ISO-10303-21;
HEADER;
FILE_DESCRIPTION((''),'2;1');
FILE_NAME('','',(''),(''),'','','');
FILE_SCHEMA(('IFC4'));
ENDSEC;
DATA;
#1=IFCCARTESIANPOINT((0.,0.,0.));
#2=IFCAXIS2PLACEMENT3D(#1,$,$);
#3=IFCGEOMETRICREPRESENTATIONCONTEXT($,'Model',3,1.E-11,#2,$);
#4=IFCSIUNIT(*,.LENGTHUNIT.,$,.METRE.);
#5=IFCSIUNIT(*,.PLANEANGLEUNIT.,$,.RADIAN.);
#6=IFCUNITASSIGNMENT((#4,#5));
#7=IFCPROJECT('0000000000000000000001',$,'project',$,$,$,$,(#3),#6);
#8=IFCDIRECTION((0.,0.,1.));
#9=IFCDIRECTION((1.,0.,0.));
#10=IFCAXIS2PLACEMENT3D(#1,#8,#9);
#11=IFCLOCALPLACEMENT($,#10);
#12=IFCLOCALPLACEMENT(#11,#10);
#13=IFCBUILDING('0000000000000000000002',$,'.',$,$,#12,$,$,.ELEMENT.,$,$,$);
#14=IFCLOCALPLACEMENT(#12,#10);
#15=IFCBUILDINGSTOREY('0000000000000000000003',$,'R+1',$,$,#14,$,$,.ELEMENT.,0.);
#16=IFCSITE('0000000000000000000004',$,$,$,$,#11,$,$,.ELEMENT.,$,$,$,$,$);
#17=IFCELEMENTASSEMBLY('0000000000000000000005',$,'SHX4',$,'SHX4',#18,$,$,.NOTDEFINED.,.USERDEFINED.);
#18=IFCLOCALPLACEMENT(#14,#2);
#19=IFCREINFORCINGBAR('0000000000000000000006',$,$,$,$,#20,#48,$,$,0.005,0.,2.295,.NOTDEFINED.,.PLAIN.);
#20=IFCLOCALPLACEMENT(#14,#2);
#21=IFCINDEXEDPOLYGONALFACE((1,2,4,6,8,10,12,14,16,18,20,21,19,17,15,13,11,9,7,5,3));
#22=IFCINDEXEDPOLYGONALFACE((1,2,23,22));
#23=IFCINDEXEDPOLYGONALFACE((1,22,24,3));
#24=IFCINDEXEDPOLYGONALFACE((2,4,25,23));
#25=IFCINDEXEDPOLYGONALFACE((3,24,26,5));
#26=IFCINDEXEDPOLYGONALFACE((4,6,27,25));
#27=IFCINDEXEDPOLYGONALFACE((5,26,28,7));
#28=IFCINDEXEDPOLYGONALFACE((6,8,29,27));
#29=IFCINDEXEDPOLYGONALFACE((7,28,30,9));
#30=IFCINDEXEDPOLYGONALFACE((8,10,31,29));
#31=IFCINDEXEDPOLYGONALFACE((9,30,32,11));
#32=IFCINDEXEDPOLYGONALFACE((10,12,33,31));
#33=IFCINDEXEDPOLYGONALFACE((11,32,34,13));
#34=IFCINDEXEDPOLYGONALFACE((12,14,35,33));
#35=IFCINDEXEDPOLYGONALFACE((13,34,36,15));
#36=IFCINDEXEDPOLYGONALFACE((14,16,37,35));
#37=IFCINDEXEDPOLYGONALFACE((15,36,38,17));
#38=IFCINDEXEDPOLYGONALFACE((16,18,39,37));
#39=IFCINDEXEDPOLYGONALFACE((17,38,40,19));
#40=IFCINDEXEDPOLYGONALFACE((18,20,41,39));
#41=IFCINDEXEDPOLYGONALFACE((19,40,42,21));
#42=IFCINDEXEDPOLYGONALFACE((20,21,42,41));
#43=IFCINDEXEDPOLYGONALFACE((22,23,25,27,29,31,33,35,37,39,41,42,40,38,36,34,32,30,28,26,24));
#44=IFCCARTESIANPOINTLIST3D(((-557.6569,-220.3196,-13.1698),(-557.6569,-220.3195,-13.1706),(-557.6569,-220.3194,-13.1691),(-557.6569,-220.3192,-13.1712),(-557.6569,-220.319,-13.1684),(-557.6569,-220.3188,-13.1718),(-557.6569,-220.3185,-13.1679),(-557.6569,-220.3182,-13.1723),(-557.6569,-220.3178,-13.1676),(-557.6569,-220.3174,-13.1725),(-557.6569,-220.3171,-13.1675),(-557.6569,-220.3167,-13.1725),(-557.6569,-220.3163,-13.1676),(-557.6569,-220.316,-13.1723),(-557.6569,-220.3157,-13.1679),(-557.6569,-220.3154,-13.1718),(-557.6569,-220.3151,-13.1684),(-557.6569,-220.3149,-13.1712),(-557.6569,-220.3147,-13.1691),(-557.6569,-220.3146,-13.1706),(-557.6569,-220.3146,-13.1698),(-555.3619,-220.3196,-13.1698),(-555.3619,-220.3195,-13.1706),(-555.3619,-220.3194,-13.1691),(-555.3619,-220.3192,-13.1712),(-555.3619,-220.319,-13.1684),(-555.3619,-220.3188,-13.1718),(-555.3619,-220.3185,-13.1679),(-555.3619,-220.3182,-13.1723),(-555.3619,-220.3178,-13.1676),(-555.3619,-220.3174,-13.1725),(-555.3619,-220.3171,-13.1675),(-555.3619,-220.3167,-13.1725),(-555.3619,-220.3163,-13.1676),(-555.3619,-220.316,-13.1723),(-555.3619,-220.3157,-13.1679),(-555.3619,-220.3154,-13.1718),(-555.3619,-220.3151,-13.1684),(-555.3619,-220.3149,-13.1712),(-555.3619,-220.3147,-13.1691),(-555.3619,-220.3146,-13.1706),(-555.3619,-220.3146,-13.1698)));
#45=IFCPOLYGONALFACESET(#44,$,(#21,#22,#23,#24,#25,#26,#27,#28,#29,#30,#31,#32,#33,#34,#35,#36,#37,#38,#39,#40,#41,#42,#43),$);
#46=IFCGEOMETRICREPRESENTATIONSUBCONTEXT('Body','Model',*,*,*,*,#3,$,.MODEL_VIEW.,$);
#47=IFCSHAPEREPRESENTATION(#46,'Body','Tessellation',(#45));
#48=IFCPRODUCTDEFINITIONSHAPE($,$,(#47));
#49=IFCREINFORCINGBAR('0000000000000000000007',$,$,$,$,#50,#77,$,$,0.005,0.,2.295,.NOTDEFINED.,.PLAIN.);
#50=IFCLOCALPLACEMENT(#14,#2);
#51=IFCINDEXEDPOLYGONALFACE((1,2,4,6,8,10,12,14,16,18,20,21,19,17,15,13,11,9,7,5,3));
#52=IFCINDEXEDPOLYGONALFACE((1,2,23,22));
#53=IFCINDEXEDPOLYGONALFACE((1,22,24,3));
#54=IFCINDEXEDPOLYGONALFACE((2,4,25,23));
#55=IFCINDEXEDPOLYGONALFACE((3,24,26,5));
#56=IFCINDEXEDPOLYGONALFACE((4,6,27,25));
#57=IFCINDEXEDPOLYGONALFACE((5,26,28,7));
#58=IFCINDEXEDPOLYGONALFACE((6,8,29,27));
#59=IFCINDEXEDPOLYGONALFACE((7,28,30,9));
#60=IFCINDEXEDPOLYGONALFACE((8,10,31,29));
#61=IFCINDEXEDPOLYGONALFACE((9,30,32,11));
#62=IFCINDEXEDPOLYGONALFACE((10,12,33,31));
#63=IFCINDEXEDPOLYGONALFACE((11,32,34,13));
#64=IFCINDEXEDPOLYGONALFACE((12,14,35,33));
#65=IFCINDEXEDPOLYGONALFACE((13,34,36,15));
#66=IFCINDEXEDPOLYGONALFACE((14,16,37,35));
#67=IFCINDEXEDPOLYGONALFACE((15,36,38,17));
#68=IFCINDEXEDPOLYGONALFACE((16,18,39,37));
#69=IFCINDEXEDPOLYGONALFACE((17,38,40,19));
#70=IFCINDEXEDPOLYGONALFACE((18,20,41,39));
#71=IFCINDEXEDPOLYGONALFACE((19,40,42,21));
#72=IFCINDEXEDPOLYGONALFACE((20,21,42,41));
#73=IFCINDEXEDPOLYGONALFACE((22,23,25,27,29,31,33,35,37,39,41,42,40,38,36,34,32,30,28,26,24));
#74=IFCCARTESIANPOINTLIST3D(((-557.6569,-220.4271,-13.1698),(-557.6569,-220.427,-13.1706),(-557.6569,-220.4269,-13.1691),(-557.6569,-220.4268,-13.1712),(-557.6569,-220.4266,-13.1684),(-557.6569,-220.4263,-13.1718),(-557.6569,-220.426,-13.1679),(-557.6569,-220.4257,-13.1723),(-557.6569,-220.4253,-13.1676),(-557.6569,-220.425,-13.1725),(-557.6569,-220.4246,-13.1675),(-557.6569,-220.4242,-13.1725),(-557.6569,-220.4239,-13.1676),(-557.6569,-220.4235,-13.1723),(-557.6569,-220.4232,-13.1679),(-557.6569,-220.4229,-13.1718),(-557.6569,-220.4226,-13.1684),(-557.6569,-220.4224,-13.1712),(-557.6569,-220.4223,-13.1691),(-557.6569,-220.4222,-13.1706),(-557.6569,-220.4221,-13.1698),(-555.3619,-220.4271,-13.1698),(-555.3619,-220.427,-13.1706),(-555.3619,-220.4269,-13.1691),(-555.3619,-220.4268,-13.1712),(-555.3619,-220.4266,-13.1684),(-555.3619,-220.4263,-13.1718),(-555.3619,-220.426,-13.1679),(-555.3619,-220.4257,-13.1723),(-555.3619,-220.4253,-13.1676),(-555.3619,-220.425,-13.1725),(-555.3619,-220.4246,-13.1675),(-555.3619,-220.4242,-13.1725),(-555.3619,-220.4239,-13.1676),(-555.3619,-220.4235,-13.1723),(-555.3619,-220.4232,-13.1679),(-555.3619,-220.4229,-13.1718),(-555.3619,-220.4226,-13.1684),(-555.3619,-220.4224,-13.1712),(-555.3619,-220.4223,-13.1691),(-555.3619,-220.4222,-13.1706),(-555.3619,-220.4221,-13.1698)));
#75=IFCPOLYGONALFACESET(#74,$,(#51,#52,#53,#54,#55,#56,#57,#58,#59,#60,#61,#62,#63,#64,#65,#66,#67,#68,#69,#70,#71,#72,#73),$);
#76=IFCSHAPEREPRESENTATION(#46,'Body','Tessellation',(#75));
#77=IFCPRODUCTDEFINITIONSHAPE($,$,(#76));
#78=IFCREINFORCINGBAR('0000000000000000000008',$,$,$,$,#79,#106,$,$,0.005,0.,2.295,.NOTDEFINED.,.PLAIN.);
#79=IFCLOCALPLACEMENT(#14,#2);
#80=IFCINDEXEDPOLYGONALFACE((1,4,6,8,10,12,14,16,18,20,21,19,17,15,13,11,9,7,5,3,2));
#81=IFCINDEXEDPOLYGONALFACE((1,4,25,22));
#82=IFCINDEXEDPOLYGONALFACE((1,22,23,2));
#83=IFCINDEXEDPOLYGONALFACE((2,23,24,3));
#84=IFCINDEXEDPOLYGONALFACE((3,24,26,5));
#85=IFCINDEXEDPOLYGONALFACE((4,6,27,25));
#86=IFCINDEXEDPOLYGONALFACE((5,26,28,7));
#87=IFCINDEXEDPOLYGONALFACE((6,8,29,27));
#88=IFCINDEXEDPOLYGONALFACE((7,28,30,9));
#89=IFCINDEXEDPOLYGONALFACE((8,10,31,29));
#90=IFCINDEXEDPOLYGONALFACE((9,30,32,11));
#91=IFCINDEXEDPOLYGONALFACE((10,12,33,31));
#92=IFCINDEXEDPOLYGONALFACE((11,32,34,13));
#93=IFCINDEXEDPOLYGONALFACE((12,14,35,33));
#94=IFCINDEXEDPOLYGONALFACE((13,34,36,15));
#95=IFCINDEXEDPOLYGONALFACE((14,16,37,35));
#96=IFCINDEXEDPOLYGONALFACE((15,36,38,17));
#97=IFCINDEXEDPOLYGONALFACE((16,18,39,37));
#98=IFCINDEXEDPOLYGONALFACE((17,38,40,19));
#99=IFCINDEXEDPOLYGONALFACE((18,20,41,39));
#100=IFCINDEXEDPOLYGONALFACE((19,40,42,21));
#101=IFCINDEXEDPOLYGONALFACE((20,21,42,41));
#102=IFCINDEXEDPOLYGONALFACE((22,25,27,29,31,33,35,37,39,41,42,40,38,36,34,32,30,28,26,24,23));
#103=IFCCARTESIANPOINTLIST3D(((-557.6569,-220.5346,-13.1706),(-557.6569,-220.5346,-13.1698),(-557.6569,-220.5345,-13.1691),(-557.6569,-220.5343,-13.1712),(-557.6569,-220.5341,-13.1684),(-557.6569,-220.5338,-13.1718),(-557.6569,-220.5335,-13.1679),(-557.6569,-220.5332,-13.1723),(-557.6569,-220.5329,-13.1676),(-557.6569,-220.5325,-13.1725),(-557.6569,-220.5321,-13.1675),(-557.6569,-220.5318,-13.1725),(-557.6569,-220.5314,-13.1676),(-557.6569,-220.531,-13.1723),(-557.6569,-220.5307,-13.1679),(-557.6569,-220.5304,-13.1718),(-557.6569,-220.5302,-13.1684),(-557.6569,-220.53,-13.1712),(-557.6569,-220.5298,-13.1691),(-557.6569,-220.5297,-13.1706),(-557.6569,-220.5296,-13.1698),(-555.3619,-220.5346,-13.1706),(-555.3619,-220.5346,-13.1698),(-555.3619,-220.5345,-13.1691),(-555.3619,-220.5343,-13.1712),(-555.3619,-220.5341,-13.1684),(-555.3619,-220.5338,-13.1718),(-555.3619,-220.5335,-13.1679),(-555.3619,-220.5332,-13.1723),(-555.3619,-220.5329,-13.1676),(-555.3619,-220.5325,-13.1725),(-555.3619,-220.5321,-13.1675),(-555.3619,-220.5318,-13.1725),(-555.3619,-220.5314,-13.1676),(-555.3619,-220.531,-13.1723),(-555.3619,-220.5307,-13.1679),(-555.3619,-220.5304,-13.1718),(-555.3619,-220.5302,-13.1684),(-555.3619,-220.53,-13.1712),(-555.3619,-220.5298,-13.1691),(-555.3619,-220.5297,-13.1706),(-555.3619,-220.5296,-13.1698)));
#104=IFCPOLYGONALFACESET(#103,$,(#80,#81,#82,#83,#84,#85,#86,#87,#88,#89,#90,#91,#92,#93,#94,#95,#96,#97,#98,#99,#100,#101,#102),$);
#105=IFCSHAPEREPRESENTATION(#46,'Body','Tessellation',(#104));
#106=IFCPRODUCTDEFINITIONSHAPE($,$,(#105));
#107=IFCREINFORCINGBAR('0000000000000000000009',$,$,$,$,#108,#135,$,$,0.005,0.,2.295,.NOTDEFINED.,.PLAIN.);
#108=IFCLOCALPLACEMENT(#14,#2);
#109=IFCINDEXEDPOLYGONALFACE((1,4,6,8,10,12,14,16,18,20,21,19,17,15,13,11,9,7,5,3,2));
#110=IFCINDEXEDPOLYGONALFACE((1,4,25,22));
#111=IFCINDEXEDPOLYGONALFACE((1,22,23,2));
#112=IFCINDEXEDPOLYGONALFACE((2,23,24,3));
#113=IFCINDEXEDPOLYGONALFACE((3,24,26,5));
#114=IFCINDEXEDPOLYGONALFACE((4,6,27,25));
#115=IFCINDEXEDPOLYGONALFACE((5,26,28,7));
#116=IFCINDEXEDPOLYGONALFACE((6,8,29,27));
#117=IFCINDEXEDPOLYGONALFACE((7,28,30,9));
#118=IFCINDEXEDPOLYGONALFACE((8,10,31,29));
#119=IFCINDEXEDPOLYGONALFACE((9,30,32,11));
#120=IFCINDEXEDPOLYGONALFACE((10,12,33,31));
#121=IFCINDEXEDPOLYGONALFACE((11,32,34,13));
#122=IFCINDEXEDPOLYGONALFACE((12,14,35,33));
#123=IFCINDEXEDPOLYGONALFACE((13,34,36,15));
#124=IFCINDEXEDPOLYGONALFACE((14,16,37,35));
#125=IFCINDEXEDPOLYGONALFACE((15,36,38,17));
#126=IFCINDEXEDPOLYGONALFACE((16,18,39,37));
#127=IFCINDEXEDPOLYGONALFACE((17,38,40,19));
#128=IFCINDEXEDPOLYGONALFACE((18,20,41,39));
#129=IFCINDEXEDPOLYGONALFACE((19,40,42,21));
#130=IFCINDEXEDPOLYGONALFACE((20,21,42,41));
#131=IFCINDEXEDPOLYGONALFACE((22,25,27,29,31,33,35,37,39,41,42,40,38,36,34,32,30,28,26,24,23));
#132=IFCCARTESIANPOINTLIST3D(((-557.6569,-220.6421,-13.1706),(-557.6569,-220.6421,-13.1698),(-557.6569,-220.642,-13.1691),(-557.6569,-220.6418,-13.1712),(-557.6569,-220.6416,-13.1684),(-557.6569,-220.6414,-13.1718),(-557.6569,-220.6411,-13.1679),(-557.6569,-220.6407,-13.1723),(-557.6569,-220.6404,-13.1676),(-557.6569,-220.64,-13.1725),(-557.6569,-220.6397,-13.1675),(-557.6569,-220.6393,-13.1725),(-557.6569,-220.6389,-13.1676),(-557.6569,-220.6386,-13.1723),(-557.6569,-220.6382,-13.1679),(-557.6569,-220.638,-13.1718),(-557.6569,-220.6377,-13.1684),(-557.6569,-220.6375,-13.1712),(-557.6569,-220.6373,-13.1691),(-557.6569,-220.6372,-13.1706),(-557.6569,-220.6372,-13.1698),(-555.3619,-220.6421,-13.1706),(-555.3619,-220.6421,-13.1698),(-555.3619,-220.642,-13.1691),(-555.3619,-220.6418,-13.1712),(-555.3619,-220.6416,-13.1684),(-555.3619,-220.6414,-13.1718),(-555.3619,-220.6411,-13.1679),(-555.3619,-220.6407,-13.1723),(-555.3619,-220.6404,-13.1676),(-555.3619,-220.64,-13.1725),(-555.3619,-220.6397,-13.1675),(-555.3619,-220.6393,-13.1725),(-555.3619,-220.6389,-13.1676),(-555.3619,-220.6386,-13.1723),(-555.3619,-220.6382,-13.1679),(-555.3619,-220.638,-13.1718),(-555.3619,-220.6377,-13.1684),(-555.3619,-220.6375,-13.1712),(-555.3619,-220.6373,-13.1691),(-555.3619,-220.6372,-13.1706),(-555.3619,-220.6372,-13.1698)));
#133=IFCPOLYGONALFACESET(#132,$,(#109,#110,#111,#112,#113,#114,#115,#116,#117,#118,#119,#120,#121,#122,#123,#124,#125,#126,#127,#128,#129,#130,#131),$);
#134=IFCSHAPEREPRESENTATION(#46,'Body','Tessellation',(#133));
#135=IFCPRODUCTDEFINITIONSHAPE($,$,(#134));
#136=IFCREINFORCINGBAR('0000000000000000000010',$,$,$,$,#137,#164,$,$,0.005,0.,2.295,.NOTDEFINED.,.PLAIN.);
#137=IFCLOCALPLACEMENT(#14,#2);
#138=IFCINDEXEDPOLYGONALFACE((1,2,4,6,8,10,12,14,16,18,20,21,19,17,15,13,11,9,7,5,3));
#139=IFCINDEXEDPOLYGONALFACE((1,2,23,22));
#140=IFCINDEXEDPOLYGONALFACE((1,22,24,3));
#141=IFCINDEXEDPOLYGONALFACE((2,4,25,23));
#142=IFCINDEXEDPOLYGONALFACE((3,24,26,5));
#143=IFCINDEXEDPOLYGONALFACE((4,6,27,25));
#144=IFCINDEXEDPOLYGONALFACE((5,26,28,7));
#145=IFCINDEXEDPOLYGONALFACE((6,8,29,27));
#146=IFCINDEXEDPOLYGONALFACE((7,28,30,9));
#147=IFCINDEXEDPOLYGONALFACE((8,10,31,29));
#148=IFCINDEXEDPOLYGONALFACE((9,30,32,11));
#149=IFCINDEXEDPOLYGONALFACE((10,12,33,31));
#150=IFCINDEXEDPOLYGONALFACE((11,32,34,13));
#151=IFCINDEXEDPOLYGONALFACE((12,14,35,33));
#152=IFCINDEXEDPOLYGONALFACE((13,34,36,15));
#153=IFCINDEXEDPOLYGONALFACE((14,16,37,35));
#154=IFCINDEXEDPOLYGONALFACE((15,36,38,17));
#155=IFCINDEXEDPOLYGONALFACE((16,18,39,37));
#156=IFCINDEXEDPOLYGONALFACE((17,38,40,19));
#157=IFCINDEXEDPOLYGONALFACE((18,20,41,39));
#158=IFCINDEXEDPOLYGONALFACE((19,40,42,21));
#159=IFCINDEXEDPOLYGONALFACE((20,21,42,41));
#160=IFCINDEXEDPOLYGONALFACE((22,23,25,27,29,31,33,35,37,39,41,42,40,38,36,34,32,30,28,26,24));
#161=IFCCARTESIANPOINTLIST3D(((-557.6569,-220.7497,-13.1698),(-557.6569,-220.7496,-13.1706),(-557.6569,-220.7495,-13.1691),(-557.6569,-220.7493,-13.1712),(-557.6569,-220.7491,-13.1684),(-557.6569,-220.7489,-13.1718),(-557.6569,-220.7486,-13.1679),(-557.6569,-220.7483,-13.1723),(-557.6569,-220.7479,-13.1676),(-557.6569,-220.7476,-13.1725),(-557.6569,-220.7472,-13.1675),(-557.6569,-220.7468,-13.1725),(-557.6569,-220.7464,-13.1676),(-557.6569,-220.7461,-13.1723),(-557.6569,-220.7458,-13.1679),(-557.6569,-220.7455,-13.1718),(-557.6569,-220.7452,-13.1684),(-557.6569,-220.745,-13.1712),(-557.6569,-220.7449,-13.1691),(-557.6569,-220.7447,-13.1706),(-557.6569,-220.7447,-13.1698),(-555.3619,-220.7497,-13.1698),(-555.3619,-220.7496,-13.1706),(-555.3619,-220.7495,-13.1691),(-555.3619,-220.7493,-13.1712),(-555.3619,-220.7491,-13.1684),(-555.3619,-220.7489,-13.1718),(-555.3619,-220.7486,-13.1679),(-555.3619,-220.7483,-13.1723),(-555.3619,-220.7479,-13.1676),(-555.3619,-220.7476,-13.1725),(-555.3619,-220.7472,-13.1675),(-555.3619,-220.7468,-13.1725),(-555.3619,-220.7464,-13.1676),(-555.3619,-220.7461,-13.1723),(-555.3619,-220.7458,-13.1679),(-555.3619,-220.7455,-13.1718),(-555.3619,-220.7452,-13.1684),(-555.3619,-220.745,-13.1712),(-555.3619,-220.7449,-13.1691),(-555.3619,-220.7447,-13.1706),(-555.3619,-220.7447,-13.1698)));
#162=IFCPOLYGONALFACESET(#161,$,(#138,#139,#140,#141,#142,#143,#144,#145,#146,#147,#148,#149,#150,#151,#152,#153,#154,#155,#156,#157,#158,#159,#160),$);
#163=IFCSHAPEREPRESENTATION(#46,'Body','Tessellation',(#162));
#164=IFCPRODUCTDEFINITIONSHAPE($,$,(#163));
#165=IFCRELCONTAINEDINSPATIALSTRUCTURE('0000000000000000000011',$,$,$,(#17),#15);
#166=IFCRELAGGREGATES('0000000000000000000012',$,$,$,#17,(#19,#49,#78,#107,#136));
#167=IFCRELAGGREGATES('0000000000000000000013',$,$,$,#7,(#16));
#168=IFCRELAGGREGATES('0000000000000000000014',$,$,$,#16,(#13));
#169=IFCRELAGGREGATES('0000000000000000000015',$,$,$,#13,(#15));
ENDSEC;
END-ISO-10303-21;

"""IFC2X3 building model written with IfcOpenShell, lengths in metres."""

from ifc_helpers import new_model, entity, si_unit, origin, origin_with_axes, place, context, subcontext, project, spatial, shape, element, aggregate, save


model = new_model("IFC2X3")

# Units and contexts
model_context = context("Model", 3, precision=1e-11, world=origin())
body_context = subcontext(model_context, "Body", "Model", "MODEL_VIEW")
ifc_project = project(units=[si_unit("LENGTHUNIT", "METRE"), si_unit("PLANEANGLEUNIT", "RADIAN")], contexts=[model_context])

# Site, building, storey
site_placement = place(None, origin_with_axes())
site = spatial("IfcSite", under=ifc_project, at=site_placement, CompositionType="ELEMENT")
building_placement = place(site_placement, origin_with_axes())
building = spatial("IfcBuilding", under=site, at=building_placement, Name=".", CompositionType="ELEMENT")
storey_placement = place(building_placement, origin_with_axes())
storey = spatial("IfcBuildingStorey", under=building, at=storey_placement, Name="R+1", CompositionType="ELEMENT", Elevation=0.0)

# Element assembly, reinforcing bars
assembly_1_placement = place(storey_placement, origin_with_axes())
assembly_1 = element("IfcElementAssembly", 1, at=assembly_1_placement, inside=storey, Name="SHX4", ObjectType="SHX4", AssemblyPlace="NOTDEFINED", PredefinedType="USERDEFINED")
reinforcing_bar_1_placement = place(assembly_1_placement, origin_with_axes())
reinforcing_bar_1 = element("IfcReinforcingBar", 2, at=reinforcing_bar_1_placement, BarLength=2.295, BarRole="NOTDEFINED", BarSurface="PLAIN", CrossSectionArea=0.0, NominalDiameter=0.005, shapes=[
    shape(body_context, "Body", "AdvancedSweptSolid", [entity("IfcSweptDiskSolid", entity("IfcPolyline", [entity("IfcCartesianPoint", [555.3619, 220.3171, 13.17]), entity("IfcCartesianPoint", [557.6569, 220.3171, 13.17])]), 0.0025, None, 0.0, 2.295)]),
    shape(body_context, "Body", "AdvancedSweptSolid", [entity("IfcSweptDiskSolid", entity("IfcPolyline", [entity("IfcCartesianPoint", [555.3619, 220.3171, 13.17]), entity("IfcCartesianPoint", [557.6569, 220.3171, 13.17])]), 0.0025, None, 0.0, 2.295)]),
])
reinforcing_bar_2_placement = place(assembly_1_placement, origin_with_axes())
reinforcing_bar_2 = element("IfcReinforcingBar", 3, at=reinforcing_bar_2_placement, BarLength=2.295, BarRole="NOTDEFINED", BarSurface="PLAIN", CrossSectionArea=0.0, NominalDiameter=0.005, shapes=[
    shape(body_context, "Body", "AdvancedSweptSolid", [entity("IfcSweptDiskSolid", entity("IfcPolyline", [entity("IfcCartesianPoint", [555.3619, 220.4246, 13.17]), entity("IfcCartesianPoint", [557.6569, 220.4246, 13.17])]), 0.0025, None, 0.0, 2.295)]),
    shape(body_context, "Body", "AdvancedSweptSolid", [entity("IfcSweptDiskSolid", entity("IfcPolyline", [entity("IfcCartesianPoint", [555.3619, 220.4246, 13.17]), entity("IfcCartesianPoint", [557.6569, 220.4246, 13.17])]), 0.0025, None, 0.0, 2.295)]),
])
reinforcing_bar_3_placement = place(assembly_1_placement, origin_with_axes())
reinforcing_bar_3 = element("IfcReinforcingBar", 4, at=reinforcing_bar_3_placement, BarLength=2.295, BarRole="NOTDEFINED", BarSurface="PLAIN", CrossSectionArea=0.0, NominalDiameter=0.005, shapes=[
    shape(body_context, "Body", "AdvancedSweptSolid", [entity("IfcSweptDiskSolid", entity("IfcPolyline", [entity("IfcCartesianPoint", [555.3619, 220.5321, 13.17]), entity("IfcCartesianPoint", [557.6569, 220.5321, 13.17])]), 0.0025, None, 0.0, 2.295)]),
    shape(body_context, "Body", "AdvancedSweptSolid", [entity("IfcSweptDiskSolid", entity("IfcPolyline", [entity("IfcCartesianPoint", [555.3619, 220.5321, 13.17]), entity("IfcCartesianPoint", [557.6569, 220.5321, 13.17])]), 0.0025, None, 0.0, 2.295)]),
])
reinforcing_bar_4_placement = place(assembly_1_placement, origin_with_axes())
reinforcing_bar_4 = element("IfcReinforcingBar", 5, at=reinforcing_bar_4_placement, BarLength=2.295, BarRole="NOTDEFINED", BarSurface="PLAIN", CrossSectionArea=0.0, NominalDiameter=0.005, shapes=[
    shape(body_context, "Body", "AdvancedSweptSolid", [entity("IfcSweptDiskSolid", entity("IfcPolyline", [entity("IfcCartesianPoint", [555.3619, 220.6397, 13.17]), entity("IfcCartesianPoint", [557.6569, 220.6397, 13.17])]), 0.0025, None, 0.0, 2.295)]),
    shape(body_context, "Body", "AdvancedSweptSolid", [entity("IfcSweptDiskSolid", entity("IfcPolyline", [entity("IfcCartesianPoint", [555.3619, 220.6397, 13.17]), entity("IfcCartesianPoint", [557.6569, 220.6397, 13.17])]), 0.0025, None, 0.0, 2.295)]),
])
reinforcing_bar_5_placement = place(assembly_1_placement, origin_with_axes())
reinforcing_bar_5 = element("IfcReinforcingBar", 6, at=reinforcing_bar_5_placement, BarLength=2.295, BarRole="NOTDEFINED", BarSurface="PLAIN", CrossSectionArea=0.0, NominalDiameter=0.005, shapes=[
    shape(body_context, "Body", "AdvancedSweptSolid", [entity("IfcSweptDiskSolid", entity("IfcPolyline", [entity("IfcCartesianPoint", [555.3619, 220.7472, 13.17]), entity("IfcCartesianPoint", [557.6569, 220.7472, 13.17])]), 0.0025, None, 0.0, 2.295)]),
    shape(body_context, "Body", "AdvancedSweptSolid", [entity("IfcSweptDiskSolid", entity("IfcPolyline", [entity("IfcCartesianPoint", [555.3619, 220.7472, 13.17]), entity("IfcCartesianPoint", [557.6569, 220.7472, 13.17])]), 0.0025, None, 0.0, 2.295)]),
])
aggregate(assembly_1, [reinforcing_bar_1, reinforcing_bar_2, reinforcing_bar_3, reinforcing_bar_4, reinforcing_bar_5])

save(model, "model.ifc")
